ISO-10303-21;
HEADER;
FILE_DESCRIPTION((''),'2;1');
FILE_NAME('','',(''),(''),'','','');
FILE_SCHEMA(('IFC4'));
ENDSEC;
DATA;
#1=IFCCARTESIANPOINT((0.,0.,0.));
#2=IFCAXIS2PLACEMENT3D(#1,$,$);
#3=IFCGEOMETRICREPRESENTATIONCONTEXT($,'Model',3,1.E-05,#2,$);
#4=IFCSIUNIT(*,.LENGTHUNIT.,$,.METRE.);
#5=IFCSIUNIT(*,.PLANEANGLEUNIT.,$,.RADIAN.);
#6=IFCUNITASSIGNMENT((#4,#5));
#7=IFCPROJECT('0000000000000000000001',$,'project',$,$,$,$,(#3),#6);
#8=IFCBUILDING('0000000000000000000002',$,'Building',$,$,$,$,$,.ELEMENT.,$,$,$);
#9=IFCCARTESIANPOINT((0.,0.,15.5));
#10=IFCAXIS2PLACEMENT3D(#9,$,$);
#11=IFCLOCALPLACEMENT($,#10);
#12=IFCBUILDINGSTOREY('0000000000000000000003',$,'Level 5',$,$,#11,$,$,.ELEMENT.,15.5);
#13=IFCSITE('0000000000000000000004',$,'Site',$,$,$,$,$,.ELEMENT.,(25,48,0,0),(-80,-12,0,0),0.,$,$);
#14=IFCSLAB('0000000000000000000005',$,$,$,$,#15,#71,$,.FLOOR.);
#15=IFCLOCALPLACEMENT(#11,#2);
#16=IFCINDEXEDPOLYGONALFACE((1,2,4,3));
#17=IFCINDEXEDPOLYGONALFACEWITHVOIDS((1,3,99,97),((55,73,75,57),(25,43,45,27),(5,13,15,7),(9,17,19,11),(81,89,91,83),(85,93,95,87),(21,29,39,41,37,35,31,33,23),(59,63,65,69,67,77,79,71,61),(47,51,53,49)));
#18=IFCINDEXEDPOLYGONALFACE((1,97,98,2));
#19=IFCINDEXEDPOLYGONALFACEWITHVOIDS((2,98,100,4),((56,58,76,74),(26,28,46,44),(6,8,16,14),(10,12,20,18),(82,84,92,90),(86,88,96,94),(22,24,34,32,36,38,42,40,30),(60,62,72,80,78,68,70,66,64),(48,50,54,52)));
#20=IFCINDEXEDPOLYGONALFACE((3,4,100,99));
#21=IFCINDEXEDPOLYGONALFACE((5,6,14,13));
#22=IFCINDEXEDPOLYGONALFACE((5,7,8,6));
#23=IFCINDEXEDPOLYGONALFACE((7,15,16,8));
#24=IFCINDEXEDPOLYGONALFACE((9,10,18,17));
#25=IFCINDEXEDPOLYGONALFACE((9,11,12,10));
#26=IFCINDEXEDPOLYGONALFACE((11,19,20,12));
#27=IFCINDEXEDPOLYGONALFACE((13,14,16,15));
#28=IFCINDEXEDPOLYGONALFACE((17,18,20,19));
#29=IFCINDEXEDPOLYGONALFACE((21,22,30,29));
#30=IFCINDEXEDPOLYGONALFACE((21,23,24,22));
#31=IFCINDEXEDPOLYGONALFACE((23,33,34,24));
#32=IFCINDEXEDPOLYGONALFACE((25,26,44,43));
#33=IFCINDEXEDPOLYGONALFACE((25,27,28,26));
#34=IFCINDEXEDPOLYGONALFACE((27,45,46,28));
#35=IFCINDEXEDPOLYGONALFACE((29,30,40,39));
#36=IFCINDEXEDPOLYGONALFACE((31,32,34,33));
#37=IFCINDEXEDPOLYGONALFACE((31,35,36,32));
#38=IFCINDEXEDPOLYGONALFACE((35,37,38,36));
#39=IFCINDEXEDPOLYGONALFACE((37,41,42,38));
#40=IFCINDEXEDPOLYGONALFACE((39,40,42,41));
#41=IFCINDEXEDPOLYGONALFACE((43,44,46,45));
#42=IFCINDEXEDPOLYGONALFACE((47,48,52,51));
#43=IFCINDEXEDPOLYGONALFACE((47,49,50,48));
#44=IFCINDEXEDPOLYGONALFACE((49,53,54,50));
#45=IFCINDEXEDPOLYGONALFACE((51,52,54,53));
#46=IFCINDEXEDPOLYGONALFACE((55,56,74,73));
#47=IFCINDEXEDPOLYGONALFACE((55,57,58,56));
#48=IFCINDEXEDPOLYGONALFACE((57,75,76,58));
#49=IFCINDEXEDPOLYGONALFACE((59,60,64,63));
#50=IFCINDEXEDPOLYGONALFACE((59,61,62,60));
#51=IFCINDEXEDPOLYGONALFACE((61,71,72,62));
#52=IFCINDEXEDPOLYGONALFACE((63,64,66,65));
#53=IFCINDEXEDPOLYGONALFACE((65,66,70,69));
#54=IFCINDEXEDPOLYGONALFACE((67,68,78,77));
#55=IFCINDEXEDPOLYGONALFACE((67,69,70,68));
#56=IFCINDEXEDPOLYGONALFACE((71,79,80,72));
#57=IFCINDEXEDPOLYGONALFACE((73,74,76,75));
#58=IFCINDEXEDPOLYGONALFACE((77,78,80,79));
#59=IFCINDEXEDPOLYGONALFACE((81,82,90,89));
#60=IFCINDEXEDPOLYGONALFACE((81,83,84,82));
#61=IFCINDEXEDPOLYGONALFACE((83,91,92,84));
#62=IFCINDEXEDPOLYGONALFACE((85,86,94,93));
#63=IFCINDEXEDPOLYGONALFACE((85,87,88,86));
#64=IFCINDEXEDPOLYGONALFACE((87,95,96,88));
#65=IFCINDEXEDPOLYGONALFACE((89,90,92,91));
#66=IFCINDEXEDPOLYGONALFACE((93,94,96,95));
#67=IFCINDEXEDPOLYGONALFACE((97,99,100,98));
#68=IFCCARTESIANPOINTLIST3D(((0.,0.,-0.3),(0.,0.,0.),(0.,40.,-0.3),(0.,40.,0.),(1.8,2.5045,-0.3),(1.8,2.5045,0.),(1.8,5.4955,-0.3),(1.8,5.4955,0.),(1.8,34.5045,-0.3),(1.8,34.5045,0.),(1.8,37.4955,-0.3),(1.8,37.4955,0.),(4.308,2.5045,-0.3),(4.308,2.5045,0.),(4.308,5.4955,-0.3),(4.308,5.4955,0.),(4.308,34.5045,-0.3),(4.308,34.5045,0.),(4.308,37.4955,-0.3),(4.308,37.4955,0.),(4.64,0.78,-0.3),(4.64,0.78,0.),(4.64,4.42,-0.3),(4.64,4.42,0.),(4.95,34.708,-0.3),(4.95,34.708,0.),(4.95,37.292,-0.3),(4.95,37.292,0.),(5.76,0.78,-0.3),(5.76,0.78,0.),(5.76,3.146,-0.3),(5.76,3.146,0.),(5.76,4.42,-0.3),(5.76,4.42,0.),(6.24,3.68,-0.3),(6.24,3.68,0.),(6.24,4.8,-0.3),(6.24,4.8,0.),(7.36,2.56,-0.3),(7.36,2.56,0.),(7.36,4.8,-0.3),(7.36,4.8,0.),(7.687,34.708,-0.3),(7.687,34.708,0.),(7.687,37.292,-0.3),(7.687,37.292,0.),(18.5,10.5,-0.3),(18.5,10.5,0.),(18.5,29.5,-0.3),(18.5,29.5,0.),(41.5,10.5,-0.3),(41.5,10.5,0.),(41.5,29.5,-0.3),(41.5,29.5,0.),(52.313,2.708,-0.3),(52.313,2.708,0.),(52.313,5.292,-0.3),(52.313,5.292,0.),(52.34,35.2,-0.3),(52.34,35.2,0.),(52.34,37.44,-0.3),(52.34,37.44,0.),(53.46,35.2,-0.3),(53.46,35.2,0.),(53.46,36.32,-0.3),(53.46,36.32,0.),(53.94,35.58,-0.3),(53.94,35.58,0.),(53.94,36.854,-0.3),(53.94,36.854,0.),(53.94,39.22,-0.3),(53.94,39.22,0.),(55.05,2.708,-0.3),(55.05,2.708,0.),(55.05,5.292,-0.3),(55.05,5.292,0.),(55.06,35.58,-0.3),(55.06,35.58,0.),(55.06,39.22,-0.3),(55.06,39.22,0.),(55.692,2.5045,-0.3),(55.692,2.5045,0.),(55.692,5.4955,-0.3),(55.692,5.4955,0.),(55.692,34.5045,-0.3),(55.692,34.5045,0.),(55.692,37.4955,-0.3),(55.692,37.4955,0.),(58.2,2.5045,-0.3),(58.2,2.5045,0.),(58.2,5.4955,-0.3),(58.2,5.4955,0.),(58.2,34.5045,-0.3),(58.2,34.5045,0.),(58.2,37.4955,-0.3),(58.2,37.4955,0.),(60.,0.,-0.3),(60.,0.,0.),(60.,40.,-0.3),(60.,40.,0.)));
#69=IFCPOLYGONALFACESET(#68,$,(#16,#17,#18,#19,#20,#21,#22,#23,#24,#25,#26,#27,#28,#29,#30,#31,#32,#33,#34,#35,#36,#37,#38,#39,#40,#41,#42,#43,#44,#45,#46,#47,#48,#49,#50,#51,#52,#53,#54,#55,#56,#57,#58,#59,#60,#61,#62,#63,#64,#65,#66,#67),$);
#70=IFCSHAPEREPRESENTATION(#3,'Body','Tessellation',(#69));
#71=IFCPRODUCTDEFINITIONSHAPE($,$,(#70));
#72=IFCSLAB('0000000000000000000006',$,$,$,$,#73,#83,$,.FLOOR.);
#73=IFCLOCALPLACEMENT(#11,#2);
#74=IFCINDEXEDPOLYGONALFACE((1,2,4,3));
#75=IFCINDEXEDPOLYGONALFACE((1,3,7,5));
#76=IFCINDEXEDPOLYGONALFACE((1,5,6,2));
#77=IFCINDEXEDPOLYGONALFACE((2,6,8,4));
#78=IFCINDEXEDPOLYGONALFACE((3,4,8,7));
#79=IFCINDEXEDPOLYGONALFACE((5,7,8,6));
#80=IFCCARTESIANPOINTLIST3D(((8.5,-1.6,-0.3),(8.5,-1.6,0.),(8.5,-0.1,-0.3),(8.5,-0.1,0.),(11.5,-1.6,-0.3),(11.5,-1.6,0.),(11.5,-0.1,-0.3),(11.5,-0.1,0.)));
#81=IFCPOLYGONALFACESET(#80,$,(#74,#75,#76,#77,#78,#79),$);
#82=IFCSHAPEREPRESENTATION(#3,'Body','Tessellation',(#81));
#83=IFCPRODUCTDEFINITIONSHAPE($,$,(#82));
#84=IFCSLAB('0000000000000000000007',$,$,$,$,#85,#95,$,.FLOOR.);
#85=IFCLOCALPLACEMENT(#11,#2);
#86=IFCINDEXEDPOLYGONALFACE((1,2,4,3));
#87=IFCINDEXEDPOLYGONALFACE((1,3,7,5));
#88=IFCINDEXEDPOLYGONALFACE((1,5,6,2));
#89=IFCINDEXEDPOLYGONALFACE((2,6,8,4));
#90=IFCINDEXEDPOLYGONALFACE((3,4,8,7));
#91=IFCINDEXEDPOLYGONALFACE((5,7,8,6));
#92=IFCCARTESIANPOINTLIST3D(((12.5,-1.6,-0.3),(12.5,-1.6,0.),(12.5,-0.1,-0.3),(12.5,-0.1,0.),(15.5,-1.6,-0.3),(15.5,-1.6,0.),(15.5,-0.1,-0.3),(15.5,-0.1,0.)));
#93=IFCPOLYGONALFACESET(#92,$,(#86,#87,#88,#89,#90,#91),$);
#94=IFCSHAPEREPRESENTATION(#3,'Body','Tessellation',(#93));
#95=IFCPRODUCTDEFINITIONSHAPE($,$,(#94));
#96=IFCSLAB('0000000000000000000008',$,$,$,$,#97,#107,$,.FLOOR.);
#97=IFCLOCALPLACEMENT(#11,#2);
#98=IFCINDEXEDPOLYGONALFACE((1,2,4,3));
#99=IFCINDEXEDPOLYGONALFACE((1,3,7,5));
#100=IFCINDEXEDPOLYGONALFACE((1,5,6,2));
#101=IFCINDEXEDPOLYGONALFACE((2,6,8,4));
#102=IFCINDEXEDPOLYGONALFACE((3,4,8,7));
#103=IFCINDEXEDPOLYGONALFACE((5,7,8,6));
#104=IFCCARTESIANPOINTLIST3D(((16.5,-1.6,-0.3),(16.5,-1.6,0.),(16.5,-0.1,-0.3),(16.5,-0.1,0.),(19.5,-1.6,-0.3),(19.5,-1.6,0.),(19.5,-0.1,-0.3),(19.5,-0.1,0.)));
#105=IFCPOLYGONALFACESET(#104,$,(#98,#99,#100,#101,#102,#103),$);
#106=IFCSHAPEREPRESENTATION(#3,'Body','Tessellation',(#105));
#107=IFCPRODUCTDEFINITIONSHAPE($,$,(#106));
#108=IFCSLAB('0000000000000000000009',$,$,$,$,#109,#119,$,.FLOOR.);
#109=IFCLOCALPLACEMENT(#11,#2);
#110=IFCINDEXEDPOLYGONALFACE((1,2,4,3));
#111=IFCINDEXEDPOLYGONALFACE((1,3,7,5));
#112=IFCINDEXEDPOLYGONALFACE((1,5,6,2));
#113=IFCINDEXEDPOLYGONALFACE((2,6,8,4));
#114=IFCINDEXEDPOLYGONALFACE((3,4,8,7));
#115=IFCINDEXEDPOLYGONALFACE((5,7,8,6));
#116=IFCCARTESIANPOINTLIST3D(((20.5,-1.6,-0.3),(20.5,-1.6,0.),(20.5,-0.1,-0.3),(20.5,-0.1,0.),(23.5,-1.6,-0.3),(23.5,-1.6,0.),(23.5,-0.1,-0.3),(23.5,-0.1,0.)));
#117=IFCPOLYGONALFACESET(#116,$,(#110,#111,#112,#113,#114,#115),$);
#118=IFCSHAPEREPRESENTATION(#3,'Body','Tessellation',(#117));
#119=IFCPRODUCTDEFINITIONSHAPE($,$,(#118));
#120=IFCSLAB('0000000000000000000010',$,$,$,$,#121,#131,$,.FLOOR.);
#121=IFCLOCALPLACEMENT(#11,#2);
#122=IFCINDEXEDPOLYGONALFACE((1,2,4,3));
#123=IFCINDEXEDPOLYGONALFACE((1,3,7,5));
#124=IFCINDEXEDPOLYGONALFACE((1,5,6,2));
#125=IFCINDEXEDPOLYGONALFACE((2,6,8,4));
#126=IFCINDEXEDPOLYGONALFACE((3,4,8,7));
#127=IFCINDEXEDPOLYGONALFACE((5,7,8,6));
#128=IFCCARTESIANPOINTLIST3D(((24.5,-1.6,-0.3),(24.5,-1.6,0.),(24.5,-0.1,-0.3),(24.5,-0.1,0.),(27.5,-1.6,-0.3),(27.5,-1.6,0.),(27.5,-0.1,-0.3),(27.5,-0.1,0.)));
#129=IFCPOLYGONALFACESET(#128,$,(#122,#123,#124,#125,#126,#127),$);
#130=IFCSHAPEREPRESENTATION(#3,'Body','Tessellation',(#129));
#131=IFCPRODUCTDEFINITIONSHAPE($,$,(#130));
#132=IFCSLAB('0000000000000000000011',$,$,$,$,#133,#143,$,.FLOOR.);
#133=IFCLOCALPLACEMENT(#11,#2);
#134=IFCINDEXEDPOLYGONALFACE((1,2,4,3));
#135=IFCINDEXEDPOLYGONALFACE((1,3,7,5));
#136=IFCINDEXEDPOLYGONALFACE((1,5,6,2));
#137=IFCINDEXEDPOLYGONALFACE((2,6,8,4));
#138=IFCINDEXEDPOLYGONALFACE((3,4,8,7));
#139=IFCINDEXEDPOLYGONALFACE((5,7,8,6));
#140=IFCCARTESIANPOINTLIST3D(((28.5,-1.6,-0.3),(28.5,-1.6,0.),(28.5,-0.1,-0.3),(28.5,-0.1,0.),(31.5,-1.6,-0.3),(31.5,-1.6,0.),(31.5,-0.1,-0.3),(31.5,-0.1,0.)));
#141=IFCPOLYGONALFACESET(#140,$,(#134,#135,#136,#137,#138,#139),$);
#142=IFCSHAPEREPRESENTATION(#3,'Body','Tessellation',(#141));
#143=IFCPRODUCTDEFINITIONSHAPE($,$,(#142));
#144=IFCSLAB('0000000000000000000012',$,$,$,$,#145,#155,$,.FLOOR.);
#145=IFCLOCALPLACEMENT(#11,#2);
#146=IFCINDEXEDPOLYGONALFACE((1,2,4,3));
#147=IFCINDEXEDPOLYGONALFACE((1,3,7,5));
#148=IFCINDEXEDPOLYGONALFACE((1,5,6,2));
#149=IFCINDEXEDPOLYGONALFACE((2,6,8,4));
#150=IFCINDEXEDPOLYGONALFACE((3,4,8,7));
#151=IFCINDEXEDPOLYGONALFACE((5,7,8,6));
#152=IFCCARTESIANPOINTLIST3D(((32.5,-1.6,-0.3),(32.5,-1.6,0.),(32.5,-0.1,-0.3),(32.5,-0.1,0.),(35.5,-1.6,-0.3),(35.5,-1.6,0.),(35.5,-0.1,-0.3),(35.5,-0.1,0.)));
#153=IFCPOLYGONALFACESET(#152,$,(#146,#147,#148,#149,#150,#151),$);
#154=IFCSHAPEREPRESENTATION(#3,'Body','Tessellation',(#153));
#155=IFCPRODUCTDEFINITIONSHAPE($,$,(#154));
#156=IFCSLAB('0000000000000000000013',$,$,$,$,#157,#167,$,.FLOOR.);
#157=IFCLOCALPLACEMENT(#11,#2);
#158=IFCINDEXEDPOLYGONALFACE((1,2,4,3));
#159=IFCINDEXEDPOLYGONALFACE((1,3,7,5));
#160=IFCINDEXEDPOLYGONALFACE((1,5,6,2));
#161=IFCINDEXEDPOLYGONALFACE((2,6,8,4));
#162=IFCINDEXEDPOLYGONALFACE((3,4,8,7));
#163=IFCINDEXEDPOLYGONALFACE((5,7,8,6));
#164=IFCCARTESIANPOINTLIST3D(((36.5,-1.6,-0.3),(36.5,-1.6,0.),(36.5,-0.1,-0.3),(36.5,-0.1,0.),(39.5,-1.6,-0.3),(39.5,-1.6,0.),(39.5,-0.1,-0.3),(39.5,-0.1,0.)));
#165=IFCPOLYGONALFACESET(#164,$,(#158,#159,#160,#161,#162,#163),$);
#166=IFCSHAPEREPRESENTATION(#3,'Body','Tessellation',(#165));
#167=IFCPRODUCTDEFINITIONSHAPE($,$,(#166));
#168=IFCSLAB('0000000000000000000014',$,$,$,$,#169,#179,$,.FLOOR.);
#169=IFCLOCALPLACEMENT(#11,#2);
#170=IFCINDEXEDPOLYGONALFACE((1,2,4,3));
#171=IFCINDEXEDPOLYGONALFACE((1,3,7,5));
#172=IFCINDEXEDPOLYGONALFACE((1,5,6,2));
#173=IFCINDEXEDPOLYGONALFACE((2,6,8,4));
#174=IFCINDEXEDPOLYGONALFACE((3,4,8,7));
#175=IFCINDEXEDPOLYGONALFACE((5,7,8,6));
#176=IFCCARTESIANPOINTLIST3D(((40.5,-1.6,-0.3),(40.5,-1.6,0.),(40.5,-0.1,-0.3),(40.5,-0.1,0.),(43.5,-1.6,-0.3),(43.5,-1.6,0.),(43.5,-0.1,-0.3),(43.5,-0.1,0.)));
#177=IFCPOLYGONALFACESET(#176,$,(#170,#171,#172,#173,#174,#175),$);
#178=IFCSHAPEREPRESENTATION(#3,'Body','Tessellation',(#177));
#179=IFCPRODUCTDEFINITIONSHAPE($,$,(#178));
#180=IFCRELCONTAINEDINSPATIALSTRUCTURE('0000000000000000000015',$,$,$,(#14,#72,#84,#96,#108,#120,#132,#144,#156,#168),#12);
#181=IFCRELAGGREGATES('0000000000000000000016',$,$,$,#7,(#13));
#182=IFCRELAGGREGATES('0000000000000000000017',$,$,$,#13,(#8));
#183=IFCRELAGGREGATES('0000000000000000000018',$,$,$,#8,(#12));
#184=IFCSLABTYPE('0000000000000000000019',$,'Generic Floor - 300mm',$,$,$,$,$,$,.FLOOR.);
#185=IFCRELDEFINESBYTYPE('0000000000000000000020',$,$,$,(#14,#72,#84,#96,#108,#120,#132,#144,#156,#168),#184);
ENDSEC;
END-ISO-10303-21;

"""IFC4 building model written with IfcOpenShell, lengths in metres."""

from ifc_helpers import new_model, si_unit, frame, origin, place, context, project, spatial, polyline, outline, extrude, type_object, element, save


model = new_model("IFC4")

# Units and contexts
model_context = context("Model", 3, precision=1e-05, world=origin())
ifc_project = project(units=[si_unit("LENGTHUNIT", "METRE"), si_unit("PLANEANGLEUNIT", "RADIAN")], contexts=[model_context])

# Site, building, storey
site = spatial("IfcSite", under=ifc_project, Name="Site", CompositionType="ELEMENT", RefLatitude=(25, 48, 0, 0), RefLongitude=(-80, -12, 0, 0), RefElevation=0.0)
building = spatial("IfcBuilding", under=site, Name="Building", CompositionType="ELEMENT")
storey_placement = place(None, frame((0.0, 0.0, 15.5)))
storey = spatial("IfcBuildingStorey", under=building, at=storey_placement, Name="Level 5", CompositionType="ELEMENT", Elevation=15.5)

# Slab, openings
slab_type = type_object("IfcSlabType", Name="Generic Floor - 300mm", PredefinedType="FLOOR")
slab_1_placement = place(None, frame((0.0, 0.0, 15.5)))
slab_1 = element("IfcSlab", 1, at=slab_1_placement, inside=storey, type_object=slab_type, PredefinedType="FLOOR", context=model_context, shape_type="SweptSolid", body=[
    extrude(outline(polyline([(0.0, 0.0), (60.0, 0.0), (60.0, 40.0), (0.0, 40.0), (0.0, 0.0)])), origin(), (0.0, 0.0, -1.0), 0.3),
])
opening_1_placement = place(None, frame((0.0, 0.0, 15.501)))
element("IfcOpeningElement", 2, at=opening_1_placement, cuts=slab_1, PredefinedType="OPENING", context=model_context, shape_type="SweptSolid", body=[
    extrude(outline(polyline([(4.64, 0.78), (5.76, 0.78), (7.36, 2.56), (7.36, 4.8), (6.24, 4.8), (6.24, 3.68), (5.76, 3.146), (5.76, 4.42), (4.64, 4.42), (4.64, 0.78)])), origin(), (0.0, 0.0, -1.0), 0.302),
])
opening_2_placement = place(None, frame((0.0, 0.0, 15.501)))
element("IfcOpeningElement", 3, at=opening_2_placement, cuts=slab_1, PredefinedType="OPENING", context=model_context, shape_type="SweptSolid", body=[
    extrude(outline(polyline([(52.34, 35.2), (53.46, 35.2), (53.46, 36.32), (53.94, 36.854), (53.94, 35.58), (55.06, 35.58), (55.06, 39.22), (53.94, 39.22), (52.34, 37.44), (52.34, 35.2)])), origin(), (0.0, 0.0, -1.0), 0.302),
])
opening_3_placement = place(None, frame((0.0, 0.0, 15.501)))
element("IfcOpeningElement", 4, at=opening_3_placement, cuts=slab_1, PredefinedType="OPENING", context=model_context, shape_type="SweptSolid", body=[
    extrude(outline(polyline([(1.8, 5.4955), (1.8, 2.5045), (4.308, 2.5045), (4.308, 5.4955), (1.8, 5.4955)])), origin(), (0.0, 0.0, -1.0), 0.302),
])
opening_4_placement = place(None, frame((0.0, 0.0, 15.501)))
element("IfcOpeningElement", 5, at=opening_4_placement, cuts=slab_1, PredefinedType="OPENING", context=model_context, shape_type="SweptSolid", body=[
    extrude(outline(polyline([(58.2, 2.5045), (58.2, 5.4955), (55.692, 5.4955), (55.692, 2.5045), (58.2, 2.5045)])), origin(), (0.0, 0.0, -1.0), 0.302),
])
opening_5_placement = place(None, frame((0.0, 0.0, 15.501)))
element("IfcOpeningElement", 6, at=opening_5_placement, cuts=slab_1, PredefinedType="OPENING", context=model_context, shape_type="SweptSolid", body=[
    extrude(outline(polyline([(55.05, 2.708), (55.05, 5.292), (52.313, 5.292), (52.313, 2.708), (55.05, 2.708)])), origin(), (0.0, 0.0, -1.0), 0.302),
])
opening_6_placement = place(None, frame((0.0, 0.0, 15.501)))
element("IfcOpeningElement", 7, at=opening_6_placement, cuts=slab_1, PredefinedType="OPENING", context=model_context, shape_type="SweptSolid", body=[
    extrude(outline(polyline([(1.8, 37.4955), (1.8, 34.5045), (4.308, 34.5045), (4.308, 37.4955), (1.8, 37.4955)])), origin(), (0.0, 0.0, -1.0), 0.302),
])
opening_7_placement = place(None, frame((0.0, 0.0, 15.501)))
element("IfcOpeningElement", 8, at=opening_7_placement, cuts=slab_1, PredefinedType="OPENING", context=model_context, shape_type="SweptSolid", body=[
    extrude(outline(polyline([(4.95, 37.292), (4.95, 34.708), (7.687, 34.708), (7.687, 37.292), (4.95, 37.292)])), origin(), (0.0, 0.0, -1.0), 0.302),
])
opening_8_placement = place(None, frame((0.0, 0.0, 15.501)))
element("IfcOpeningElement", 9, at=opening_8_placement, cuts=slab_1, PredefinedType="OPENING", context=model_context, shape_type="SweptSolid", body=[
    extrude(outline(polyline([(58.2, 34.5045), (58.2, 37.4955), (55.692, 37.4955), (55.692, 34.5045), (58.2, 34.5045)])), origin(), (0.0, 0.0, -1.0), 0.302),
])
opening_9_placement = place(None, frame((0.0, 0.0, 15.501)))
element("IfcOpeningElement", 10, at=opening_9_placement, cuts=slab_1, PredefinedType="OPENING", context=model_context, shape_type="SweptSolid", body=[
    extrude(outline(polyline([(18.5, 10.5), (41.5, 10.5), (41.5, 29.5), (18.5, 29.5), (18.5, 10.5)])), origin(), (0.0, 0.0, -1.0), 0.302),
])

# Slabs
slab_2_placement = place(None, frame((0.0, 0.0, 15.5)))
element("IfcSlab", 11, at=slab_2_placement, inside=storey, type_object=slab_type, PredefinedType="FLOOR", context=model_context, shape_type="SweptSolid", body=[
    extrude(outline(polyline([(11.5, -0.1), (8.5, -0.1), (8.5, -1.6), (11.5, -1.6), (11.5, -0.1)])), origin(), (0.0, 0.0, -1.0), 0.3),
])
slab_3_placement = place(None, frame((0.0, 0.0, 15.5)))
element("IfcSlab", 12, at=slab_3_placement, inside=storey, type_object=slab_type, PredefinedType="FLOOR", context=model_context, shape_type="SweptSolid", body=[
    extrude(outline(polyline([(12.5, -0.1), (12.5, -1.6), (15.5, -1.6), (15.5, -0.1), (12.5, -0.1)])), origin(), (0.0, 0.0, -1.0), 0.3),
])
slab_4_placement = place(None, frame((0.0, 0.0, 15.5)))
element("IfcSlab", 13, at=slab_4_placement, inside=storey, type_object=slab_type, PredefinedType="FLOOR", context=model_context, shape_type="SweptSolid", body=[
    extrude(outline(polyline([(19.5, -0.1), (16.5, -0.1), (16.5, -1.6), (19.5, -1.6), (19.5, -0.1)])), origin(), (0.0, 0.0, -1.0), 0.3),
])
slab_5_placement = place(None, frame((0.0, 0.0, 15.5)))
element("IfcSlab", 14, at=slab_5_placement, inside=storey, type_object=slab_type, PredefinedType="FLOOR", context=model_context, shape_type="SweptSolid", body=[
    extrude(outline(polyline([(20.5, -0.1), (20.5, -1.6), (23.5, -1.6), (23.5, -0.1), (20.5, -0.1)])), origin(), (0.0, 0.0, -1.0), 0.3),
])
slab_6_placement = place(None, frame((0.0, 0.0, 15.5)))
element("IfcSlab", 15, at=slab_6_placement, inside=storey, type_object=slab_type, PredefinedType="FLOOR", context=model_context, shape_type="SweptSolid", body=[
    extrude(outline(polyline([(27.5, -0.1), (24.5, -0.1), (24.5, -1.6), (27.5, -1.6), (27.5, -0.1)])), origin(), (0.0, 0.0, -1.0), 0.3),
])
slab_7_placement = place(None, frame((0.0, 0.0, 15.5)))
element("IfcSlab", 16, at=slab_7_placement, inside=storey, type_object=slab_type, PredefinedType="FLOOR", context=model_context, shape_type="SweptSolid", body=[
    extrude(outline(polyline([(28.5, -0.1), (28.5, -1.6), (31.5, -1.6), (31.5, -0.1), (28.5, -0.1)])), origin(), (0.0, 0.0, -1.0), 0.3),
])
slab_8_placement = place(None, frame((0.0, 0.0, 15.5)))
element("IfcSlab", 17, at=slab_8_placement, inside=storey, type_object=slab_type, PredefinedType="FLOOR", context=model_context, shape_type="SweptSolid", body=[
    extrude(outline(polyline([(35.5, -0.1), (32.5, -0.1), (32.5, -1.6), (35.5, -1.6), (35.5, -0.1)])), origin(), (0.0, 0.0, -1.0), 0.3),
])
slab_9_placement = place(None, frame((0.0, 0.0, 15.5)))
element("IfcSlab", 18, at=slab_9_placement, inside=storey, type_object=slab_type, PredefinedType="FLOOR", context=model_context, shape_type="SweptSolid", body=[
    extrude(outline(polyline([(36.5, -0.1), (36.5, -1.6), (39.5, -1.6), (39.5, -0.1), (36.5, -0.1)])), origin(), (0.0, 0.0, -1.0), 0.3),
])
slab_10_placement = place(None, frame((0.0, 0.0, 15.5)))
element("IfcSlab", 19, at=slab_10_placement, inside=storey, type_object=slab_type, PredefinedType="FLOOR", context=model_context, shape_type="SweptSolid", body=[
    extrude(outline(polyline([(43.5, -0.1), (40.5, -0.1), (40.5, -1.6), (43.5, -1.6), (43.5, -0.1)])), origin(), (0.0, 0.0, -1.0), 0.3),
])

save(model, "model.ifc")
